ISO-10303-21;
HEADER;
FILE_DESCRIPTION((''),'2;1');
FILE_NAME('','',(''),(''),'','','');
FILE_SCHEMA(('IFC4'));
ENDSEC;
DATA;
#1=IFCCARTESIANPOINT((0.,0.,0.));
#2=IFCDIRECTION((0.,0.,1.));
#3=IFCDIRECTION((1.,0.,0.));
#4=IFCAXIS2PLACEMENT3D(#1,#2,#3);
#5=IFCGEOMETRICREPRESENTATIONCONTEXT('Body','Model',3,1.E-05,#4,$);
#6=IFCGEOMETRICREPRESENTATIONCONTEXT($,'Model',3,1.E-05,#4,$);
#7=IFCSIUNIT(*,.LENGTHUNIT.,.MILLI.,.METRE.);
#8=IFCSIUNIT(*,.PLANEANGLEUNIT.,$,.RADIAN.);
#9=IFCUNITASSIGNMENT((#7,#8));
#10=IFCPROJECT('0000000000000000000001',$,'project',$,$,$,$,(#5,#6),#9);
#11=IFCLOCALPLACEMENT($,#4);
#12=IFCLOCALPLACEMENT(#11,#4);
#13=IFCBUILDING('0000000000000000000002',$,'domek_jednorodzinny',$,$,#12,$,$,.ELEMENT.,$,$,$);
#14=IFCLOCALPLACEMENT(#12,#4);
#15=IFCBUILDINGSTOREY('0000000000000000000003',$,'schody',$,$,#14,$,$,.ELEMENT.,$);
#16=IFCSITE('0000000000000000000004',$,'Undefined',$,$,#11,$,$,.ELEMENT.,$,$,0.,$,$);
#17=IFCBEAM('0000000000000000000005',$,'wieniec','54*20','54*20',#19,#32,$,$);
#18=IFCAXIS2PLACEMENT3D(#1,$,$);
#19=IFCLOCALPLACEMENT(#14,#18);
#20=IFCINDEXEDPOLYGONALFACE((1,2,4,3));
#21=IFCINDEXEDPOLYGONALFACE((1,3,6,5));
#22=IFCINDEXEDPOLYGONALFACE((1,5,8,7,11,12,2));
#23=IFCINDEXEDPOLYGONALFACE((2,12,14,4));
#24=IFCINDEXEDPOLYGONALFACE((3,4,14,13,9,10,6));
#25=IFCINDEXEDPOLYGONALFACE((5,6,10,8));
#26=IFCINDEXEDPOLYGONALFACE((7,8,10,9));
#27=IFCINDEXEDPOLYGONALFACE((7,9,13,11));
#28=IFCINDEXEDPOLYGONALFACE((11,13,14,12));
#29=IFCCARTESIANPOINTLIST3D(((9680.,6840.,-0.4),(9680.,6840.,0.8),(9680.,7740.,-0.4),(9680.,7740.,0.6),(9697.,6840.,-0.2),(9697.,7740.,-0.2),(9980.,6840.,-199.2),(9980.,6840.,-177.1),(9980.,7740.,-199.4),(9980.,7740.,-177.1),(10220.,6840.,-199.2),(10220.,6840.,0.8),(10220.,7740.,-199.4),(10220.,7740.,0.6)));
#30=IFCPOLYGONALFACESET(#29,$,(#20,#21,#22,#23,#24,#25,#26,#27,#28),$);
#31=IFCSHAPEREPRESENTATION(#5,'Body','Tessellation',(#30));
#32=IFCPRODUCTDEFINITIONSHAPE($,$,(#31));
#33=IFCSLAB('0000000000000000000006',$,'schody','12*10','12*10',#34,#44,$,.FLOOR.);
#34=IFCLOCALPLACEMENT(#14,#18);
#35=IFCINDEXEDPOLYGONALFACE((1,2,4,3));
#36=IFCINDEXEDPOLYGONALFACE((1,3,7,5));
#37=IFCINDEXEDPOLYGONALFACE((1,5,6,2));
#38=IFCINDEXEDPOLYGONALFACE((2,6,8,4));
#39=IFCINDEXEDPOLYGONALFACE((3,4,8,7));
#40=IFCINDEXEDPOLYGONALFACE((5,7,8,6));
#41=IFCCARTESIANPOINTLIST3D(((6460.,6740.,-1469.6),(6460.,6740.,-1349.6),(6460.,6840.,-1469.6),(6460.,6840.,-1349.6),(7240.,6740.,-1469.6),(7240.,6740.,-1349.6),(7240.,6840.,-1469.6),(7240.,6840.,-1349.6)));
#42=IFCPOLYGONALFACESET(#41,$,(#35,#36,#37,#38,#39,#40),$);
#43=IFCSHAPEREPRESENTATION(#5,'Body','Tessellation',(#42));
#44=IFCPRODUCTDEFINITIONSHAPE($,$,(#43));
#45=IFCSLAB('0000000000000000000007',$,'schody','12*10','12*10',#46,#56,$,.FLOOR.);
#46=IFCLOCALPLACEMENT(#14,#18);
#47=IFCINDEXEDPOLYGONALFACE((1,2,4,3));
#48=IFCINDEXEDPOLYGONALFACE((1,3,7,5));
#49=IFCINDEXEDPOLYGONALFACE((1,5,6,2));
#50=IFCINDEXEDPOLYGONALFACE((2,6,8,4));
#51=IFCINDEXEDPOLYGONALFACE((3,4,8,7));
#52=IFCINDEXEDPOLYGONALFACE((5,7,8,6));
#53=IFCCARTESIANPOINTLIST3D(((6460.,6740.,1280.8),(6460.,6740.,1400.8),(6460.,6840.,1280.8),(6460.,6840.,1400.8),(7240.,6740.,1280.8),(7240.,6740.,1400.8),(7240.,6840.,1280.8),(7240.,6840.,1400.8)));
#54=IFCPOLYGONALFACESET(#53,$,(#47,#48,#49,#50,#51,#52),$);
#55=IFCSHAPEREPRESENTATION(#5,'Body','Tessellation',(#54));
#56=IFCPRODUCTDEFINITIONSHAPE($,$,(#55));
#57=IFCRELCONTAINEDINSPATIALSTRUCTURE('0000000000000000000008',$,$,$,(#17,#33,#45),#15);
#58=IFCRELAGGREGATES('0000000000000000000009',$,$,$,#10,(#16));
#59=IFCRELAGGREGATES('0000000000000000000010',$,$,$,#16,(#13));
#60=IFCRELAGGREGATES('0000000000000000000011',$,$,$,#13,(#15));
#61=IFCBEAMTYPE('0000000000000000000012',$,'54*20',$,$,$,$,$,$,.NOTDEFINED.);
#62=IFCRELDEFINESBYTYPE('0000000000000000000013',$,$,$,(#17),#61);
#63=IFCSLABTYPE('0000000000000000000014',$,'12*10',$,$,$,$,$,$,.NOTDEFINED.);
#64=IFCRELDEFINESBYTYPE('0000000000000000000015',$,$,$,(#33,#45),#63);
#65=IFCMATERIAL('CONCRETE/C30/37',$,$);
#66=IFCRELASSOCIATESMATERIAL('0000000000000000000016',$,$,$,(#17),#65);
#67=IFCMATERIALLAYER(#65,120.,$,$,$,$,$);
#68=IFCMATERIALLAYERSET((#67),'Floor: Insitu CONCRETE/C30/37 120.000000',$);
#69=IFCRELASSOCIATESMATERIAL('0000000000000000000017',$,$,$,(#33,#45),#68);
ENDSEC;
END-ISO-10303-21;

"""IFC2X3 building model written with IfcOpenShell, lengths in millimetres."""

from ifc_helpers import new_model, si_unit, frame, origin_with_axes, origin_2d_with_axis, place, context, project, spatial, polyline, rectangle, outline, extrude, material, layer, layer_set, layer_usage, type_object, element, save


model = new_model("IFC2X3")

# Units and contexts
model_context_1 = context("Model", 3, precision=1e-05, world=origin_with_axes(), identifier="Body")
model_context_2 = context("Model", 3, precision=1e-05, world=origin_with_axes())
ifc_project = project(units=[si_unit("LENGTHUNIT", "METRE", prefix="MILLI"), si_unit("PLANEANGLEUNIT", "RADIAN")], contexts=[model_context_1, model_context_2])

# Site, building, storey
site_placement = place(None, origin_with_axes())
site = spatial("IfcSite", under=ifc_project, at=site_placement, Name="Undefined", CompositionType="ELEMENT", RefElevation=0.0)
building_placement = place(site_placement, origin_with_axes())
building = spatial("IfcBuilding", under=site, at=building_placement, Name="domek_jednorodzinny", CompositionType="ELEMENT")
storey_placement = place(building_placement, origin_with_axes())
storey = spatial("IfcBuildingStorey", under=building, at=storey_placement, Name="schody", CompositionType="ELEMENT")

# Beam, opening
ifc_material = material(Name="CONCRETE/C30/37")
beam_type = type_object("IfcBeamType", Name="54*20", PredefinedType="NOTDEFINED")
beam_placement = place(storey_placement, frame((9950.0, 7740.0, -99.4), z_axis=(0.0, 0.000179, 1.0), x_axis=(0.0, -1.0, 0.000179)))
beam = element("IfcBeam", 1, at=beam_placement, inside=storey, type_object=beam_type, material=ifc_material, Name="wieniec", Description="54*20", ObjectType="54*20", context=model_context_1, shape_type="SweptSolid", body=[
    extrude(rectangle(XDim=540.0, YDim=200.0, at=origin_2d_with_axis()), frame((900.0, 0.0, 0.0), z_axis=(-1.0, 0.0, 0.0), x_axis=(0.0, -1.0, 0.0)), (0.0, 0.0, 1.0), 900.0),
])
opening_1_placement = place(storey_placement, frame((9950.0, 7740.0, -99.4), z_axis=(0.0, 0.000179, 1.0), x_axis=(0.0, -1.0, 0.000179)))
element("IfcOpeningElement", 2, at=opening_1_placement, cuts=beam, ObjectType="Recess", context=model_context_1, shape_type="SweptSolid", body=[
    extrude(outline(polyline([(0.0, 0.0), (333.7, 0.0), (346.0, 19.6), (91.7, 178.7), (-14.3, 9.1), (0.0, 0.0)])), frame((903.0, -253.0, 99.0), z_axis=(-1.0, 0.0, 0.000179), x_axis=(-0.000095, 0.847998, -0.529999)), (0.0, 0.0, 1.0), 906.0),
])

# Slabs
ifc_layer_1 = layer(ifc_material, 120.0)
ifc_layer_set_1 = layer_set([ifc_layer_1], Name="Floor: Insitu CONCRETE/C30/37 120.000000")
ifc_layer_usage_1 = layer_usage(ifc_layer_set_1, "AXIS3", "POSITIVE", -60.0)
slab_type_1 = type_object("IfcSlabType", Name="12*10", PredefinedType="NOTDEFINED")
slab_1_placement = place(storey_placement, frame((7240.0, 6840.0, -1409.6), z_axis=(0.0, 0.0, 1.0), x_axis=(-1.0, 0.0, 0.0)))
element("IfcSlab", 3, at=slab_1_placement, inside=storey, type_object=slab_type_1, material=ifc_layer_usage_1, Name="schody", Description="12*10", ObjectType="12*10", PredefinedType="FLOOR", context=model_context_1, shape_type="SweptSolid", body=[
    extrude(outline(polyline([(0.0, 0.0), (780.0, 0.0), (780.0, 100.0), (0.0, 100.0), (0.0, 0.0)])), frame((0.0, 0.0, -60.0), z_axis=(0.0, 0.0, 1.0), x_axis=(1.0, 0.0, 0.0)), (0.0, 0.0, 1.0), 120.0),
])
ifc_layer_usage_2 = layer_usage(ifc_layer_set_1, "AXIS3", "POSITIVE", -60.0)
slab_2_placement = place(storey_placement, frame((7240.0, 6840.0, 1340.8), z_axis=(0.0, 0.0, 1.0), x_axis=(-1.0, 0.0, 0.0)))
element("IfcSlab", 4, at=slab_2_placement, inside=storey, type_object=slab_type_1, material=ifc_layer_usage_2, Name="schody", Description="12*10", ObjectType="12*10", PredefinedType="FLOOR", context=model_context_1, shape_type="SweptSolid", body=[
    extrude(outline(polyline([(0.0, 0.0), (780.0, 0.0), (780.0, 100.0), (0.0, 100.0), (0.0, 0.0)])), frame((0.0, 0.0, -60.0), z_axis=(0.0, 0.0, 1.0), x_axis=(1.0, 0.0, 0.0)), (0.0, 0.0, 1.0), 120.0),
])

save(model, "model.ifc")
